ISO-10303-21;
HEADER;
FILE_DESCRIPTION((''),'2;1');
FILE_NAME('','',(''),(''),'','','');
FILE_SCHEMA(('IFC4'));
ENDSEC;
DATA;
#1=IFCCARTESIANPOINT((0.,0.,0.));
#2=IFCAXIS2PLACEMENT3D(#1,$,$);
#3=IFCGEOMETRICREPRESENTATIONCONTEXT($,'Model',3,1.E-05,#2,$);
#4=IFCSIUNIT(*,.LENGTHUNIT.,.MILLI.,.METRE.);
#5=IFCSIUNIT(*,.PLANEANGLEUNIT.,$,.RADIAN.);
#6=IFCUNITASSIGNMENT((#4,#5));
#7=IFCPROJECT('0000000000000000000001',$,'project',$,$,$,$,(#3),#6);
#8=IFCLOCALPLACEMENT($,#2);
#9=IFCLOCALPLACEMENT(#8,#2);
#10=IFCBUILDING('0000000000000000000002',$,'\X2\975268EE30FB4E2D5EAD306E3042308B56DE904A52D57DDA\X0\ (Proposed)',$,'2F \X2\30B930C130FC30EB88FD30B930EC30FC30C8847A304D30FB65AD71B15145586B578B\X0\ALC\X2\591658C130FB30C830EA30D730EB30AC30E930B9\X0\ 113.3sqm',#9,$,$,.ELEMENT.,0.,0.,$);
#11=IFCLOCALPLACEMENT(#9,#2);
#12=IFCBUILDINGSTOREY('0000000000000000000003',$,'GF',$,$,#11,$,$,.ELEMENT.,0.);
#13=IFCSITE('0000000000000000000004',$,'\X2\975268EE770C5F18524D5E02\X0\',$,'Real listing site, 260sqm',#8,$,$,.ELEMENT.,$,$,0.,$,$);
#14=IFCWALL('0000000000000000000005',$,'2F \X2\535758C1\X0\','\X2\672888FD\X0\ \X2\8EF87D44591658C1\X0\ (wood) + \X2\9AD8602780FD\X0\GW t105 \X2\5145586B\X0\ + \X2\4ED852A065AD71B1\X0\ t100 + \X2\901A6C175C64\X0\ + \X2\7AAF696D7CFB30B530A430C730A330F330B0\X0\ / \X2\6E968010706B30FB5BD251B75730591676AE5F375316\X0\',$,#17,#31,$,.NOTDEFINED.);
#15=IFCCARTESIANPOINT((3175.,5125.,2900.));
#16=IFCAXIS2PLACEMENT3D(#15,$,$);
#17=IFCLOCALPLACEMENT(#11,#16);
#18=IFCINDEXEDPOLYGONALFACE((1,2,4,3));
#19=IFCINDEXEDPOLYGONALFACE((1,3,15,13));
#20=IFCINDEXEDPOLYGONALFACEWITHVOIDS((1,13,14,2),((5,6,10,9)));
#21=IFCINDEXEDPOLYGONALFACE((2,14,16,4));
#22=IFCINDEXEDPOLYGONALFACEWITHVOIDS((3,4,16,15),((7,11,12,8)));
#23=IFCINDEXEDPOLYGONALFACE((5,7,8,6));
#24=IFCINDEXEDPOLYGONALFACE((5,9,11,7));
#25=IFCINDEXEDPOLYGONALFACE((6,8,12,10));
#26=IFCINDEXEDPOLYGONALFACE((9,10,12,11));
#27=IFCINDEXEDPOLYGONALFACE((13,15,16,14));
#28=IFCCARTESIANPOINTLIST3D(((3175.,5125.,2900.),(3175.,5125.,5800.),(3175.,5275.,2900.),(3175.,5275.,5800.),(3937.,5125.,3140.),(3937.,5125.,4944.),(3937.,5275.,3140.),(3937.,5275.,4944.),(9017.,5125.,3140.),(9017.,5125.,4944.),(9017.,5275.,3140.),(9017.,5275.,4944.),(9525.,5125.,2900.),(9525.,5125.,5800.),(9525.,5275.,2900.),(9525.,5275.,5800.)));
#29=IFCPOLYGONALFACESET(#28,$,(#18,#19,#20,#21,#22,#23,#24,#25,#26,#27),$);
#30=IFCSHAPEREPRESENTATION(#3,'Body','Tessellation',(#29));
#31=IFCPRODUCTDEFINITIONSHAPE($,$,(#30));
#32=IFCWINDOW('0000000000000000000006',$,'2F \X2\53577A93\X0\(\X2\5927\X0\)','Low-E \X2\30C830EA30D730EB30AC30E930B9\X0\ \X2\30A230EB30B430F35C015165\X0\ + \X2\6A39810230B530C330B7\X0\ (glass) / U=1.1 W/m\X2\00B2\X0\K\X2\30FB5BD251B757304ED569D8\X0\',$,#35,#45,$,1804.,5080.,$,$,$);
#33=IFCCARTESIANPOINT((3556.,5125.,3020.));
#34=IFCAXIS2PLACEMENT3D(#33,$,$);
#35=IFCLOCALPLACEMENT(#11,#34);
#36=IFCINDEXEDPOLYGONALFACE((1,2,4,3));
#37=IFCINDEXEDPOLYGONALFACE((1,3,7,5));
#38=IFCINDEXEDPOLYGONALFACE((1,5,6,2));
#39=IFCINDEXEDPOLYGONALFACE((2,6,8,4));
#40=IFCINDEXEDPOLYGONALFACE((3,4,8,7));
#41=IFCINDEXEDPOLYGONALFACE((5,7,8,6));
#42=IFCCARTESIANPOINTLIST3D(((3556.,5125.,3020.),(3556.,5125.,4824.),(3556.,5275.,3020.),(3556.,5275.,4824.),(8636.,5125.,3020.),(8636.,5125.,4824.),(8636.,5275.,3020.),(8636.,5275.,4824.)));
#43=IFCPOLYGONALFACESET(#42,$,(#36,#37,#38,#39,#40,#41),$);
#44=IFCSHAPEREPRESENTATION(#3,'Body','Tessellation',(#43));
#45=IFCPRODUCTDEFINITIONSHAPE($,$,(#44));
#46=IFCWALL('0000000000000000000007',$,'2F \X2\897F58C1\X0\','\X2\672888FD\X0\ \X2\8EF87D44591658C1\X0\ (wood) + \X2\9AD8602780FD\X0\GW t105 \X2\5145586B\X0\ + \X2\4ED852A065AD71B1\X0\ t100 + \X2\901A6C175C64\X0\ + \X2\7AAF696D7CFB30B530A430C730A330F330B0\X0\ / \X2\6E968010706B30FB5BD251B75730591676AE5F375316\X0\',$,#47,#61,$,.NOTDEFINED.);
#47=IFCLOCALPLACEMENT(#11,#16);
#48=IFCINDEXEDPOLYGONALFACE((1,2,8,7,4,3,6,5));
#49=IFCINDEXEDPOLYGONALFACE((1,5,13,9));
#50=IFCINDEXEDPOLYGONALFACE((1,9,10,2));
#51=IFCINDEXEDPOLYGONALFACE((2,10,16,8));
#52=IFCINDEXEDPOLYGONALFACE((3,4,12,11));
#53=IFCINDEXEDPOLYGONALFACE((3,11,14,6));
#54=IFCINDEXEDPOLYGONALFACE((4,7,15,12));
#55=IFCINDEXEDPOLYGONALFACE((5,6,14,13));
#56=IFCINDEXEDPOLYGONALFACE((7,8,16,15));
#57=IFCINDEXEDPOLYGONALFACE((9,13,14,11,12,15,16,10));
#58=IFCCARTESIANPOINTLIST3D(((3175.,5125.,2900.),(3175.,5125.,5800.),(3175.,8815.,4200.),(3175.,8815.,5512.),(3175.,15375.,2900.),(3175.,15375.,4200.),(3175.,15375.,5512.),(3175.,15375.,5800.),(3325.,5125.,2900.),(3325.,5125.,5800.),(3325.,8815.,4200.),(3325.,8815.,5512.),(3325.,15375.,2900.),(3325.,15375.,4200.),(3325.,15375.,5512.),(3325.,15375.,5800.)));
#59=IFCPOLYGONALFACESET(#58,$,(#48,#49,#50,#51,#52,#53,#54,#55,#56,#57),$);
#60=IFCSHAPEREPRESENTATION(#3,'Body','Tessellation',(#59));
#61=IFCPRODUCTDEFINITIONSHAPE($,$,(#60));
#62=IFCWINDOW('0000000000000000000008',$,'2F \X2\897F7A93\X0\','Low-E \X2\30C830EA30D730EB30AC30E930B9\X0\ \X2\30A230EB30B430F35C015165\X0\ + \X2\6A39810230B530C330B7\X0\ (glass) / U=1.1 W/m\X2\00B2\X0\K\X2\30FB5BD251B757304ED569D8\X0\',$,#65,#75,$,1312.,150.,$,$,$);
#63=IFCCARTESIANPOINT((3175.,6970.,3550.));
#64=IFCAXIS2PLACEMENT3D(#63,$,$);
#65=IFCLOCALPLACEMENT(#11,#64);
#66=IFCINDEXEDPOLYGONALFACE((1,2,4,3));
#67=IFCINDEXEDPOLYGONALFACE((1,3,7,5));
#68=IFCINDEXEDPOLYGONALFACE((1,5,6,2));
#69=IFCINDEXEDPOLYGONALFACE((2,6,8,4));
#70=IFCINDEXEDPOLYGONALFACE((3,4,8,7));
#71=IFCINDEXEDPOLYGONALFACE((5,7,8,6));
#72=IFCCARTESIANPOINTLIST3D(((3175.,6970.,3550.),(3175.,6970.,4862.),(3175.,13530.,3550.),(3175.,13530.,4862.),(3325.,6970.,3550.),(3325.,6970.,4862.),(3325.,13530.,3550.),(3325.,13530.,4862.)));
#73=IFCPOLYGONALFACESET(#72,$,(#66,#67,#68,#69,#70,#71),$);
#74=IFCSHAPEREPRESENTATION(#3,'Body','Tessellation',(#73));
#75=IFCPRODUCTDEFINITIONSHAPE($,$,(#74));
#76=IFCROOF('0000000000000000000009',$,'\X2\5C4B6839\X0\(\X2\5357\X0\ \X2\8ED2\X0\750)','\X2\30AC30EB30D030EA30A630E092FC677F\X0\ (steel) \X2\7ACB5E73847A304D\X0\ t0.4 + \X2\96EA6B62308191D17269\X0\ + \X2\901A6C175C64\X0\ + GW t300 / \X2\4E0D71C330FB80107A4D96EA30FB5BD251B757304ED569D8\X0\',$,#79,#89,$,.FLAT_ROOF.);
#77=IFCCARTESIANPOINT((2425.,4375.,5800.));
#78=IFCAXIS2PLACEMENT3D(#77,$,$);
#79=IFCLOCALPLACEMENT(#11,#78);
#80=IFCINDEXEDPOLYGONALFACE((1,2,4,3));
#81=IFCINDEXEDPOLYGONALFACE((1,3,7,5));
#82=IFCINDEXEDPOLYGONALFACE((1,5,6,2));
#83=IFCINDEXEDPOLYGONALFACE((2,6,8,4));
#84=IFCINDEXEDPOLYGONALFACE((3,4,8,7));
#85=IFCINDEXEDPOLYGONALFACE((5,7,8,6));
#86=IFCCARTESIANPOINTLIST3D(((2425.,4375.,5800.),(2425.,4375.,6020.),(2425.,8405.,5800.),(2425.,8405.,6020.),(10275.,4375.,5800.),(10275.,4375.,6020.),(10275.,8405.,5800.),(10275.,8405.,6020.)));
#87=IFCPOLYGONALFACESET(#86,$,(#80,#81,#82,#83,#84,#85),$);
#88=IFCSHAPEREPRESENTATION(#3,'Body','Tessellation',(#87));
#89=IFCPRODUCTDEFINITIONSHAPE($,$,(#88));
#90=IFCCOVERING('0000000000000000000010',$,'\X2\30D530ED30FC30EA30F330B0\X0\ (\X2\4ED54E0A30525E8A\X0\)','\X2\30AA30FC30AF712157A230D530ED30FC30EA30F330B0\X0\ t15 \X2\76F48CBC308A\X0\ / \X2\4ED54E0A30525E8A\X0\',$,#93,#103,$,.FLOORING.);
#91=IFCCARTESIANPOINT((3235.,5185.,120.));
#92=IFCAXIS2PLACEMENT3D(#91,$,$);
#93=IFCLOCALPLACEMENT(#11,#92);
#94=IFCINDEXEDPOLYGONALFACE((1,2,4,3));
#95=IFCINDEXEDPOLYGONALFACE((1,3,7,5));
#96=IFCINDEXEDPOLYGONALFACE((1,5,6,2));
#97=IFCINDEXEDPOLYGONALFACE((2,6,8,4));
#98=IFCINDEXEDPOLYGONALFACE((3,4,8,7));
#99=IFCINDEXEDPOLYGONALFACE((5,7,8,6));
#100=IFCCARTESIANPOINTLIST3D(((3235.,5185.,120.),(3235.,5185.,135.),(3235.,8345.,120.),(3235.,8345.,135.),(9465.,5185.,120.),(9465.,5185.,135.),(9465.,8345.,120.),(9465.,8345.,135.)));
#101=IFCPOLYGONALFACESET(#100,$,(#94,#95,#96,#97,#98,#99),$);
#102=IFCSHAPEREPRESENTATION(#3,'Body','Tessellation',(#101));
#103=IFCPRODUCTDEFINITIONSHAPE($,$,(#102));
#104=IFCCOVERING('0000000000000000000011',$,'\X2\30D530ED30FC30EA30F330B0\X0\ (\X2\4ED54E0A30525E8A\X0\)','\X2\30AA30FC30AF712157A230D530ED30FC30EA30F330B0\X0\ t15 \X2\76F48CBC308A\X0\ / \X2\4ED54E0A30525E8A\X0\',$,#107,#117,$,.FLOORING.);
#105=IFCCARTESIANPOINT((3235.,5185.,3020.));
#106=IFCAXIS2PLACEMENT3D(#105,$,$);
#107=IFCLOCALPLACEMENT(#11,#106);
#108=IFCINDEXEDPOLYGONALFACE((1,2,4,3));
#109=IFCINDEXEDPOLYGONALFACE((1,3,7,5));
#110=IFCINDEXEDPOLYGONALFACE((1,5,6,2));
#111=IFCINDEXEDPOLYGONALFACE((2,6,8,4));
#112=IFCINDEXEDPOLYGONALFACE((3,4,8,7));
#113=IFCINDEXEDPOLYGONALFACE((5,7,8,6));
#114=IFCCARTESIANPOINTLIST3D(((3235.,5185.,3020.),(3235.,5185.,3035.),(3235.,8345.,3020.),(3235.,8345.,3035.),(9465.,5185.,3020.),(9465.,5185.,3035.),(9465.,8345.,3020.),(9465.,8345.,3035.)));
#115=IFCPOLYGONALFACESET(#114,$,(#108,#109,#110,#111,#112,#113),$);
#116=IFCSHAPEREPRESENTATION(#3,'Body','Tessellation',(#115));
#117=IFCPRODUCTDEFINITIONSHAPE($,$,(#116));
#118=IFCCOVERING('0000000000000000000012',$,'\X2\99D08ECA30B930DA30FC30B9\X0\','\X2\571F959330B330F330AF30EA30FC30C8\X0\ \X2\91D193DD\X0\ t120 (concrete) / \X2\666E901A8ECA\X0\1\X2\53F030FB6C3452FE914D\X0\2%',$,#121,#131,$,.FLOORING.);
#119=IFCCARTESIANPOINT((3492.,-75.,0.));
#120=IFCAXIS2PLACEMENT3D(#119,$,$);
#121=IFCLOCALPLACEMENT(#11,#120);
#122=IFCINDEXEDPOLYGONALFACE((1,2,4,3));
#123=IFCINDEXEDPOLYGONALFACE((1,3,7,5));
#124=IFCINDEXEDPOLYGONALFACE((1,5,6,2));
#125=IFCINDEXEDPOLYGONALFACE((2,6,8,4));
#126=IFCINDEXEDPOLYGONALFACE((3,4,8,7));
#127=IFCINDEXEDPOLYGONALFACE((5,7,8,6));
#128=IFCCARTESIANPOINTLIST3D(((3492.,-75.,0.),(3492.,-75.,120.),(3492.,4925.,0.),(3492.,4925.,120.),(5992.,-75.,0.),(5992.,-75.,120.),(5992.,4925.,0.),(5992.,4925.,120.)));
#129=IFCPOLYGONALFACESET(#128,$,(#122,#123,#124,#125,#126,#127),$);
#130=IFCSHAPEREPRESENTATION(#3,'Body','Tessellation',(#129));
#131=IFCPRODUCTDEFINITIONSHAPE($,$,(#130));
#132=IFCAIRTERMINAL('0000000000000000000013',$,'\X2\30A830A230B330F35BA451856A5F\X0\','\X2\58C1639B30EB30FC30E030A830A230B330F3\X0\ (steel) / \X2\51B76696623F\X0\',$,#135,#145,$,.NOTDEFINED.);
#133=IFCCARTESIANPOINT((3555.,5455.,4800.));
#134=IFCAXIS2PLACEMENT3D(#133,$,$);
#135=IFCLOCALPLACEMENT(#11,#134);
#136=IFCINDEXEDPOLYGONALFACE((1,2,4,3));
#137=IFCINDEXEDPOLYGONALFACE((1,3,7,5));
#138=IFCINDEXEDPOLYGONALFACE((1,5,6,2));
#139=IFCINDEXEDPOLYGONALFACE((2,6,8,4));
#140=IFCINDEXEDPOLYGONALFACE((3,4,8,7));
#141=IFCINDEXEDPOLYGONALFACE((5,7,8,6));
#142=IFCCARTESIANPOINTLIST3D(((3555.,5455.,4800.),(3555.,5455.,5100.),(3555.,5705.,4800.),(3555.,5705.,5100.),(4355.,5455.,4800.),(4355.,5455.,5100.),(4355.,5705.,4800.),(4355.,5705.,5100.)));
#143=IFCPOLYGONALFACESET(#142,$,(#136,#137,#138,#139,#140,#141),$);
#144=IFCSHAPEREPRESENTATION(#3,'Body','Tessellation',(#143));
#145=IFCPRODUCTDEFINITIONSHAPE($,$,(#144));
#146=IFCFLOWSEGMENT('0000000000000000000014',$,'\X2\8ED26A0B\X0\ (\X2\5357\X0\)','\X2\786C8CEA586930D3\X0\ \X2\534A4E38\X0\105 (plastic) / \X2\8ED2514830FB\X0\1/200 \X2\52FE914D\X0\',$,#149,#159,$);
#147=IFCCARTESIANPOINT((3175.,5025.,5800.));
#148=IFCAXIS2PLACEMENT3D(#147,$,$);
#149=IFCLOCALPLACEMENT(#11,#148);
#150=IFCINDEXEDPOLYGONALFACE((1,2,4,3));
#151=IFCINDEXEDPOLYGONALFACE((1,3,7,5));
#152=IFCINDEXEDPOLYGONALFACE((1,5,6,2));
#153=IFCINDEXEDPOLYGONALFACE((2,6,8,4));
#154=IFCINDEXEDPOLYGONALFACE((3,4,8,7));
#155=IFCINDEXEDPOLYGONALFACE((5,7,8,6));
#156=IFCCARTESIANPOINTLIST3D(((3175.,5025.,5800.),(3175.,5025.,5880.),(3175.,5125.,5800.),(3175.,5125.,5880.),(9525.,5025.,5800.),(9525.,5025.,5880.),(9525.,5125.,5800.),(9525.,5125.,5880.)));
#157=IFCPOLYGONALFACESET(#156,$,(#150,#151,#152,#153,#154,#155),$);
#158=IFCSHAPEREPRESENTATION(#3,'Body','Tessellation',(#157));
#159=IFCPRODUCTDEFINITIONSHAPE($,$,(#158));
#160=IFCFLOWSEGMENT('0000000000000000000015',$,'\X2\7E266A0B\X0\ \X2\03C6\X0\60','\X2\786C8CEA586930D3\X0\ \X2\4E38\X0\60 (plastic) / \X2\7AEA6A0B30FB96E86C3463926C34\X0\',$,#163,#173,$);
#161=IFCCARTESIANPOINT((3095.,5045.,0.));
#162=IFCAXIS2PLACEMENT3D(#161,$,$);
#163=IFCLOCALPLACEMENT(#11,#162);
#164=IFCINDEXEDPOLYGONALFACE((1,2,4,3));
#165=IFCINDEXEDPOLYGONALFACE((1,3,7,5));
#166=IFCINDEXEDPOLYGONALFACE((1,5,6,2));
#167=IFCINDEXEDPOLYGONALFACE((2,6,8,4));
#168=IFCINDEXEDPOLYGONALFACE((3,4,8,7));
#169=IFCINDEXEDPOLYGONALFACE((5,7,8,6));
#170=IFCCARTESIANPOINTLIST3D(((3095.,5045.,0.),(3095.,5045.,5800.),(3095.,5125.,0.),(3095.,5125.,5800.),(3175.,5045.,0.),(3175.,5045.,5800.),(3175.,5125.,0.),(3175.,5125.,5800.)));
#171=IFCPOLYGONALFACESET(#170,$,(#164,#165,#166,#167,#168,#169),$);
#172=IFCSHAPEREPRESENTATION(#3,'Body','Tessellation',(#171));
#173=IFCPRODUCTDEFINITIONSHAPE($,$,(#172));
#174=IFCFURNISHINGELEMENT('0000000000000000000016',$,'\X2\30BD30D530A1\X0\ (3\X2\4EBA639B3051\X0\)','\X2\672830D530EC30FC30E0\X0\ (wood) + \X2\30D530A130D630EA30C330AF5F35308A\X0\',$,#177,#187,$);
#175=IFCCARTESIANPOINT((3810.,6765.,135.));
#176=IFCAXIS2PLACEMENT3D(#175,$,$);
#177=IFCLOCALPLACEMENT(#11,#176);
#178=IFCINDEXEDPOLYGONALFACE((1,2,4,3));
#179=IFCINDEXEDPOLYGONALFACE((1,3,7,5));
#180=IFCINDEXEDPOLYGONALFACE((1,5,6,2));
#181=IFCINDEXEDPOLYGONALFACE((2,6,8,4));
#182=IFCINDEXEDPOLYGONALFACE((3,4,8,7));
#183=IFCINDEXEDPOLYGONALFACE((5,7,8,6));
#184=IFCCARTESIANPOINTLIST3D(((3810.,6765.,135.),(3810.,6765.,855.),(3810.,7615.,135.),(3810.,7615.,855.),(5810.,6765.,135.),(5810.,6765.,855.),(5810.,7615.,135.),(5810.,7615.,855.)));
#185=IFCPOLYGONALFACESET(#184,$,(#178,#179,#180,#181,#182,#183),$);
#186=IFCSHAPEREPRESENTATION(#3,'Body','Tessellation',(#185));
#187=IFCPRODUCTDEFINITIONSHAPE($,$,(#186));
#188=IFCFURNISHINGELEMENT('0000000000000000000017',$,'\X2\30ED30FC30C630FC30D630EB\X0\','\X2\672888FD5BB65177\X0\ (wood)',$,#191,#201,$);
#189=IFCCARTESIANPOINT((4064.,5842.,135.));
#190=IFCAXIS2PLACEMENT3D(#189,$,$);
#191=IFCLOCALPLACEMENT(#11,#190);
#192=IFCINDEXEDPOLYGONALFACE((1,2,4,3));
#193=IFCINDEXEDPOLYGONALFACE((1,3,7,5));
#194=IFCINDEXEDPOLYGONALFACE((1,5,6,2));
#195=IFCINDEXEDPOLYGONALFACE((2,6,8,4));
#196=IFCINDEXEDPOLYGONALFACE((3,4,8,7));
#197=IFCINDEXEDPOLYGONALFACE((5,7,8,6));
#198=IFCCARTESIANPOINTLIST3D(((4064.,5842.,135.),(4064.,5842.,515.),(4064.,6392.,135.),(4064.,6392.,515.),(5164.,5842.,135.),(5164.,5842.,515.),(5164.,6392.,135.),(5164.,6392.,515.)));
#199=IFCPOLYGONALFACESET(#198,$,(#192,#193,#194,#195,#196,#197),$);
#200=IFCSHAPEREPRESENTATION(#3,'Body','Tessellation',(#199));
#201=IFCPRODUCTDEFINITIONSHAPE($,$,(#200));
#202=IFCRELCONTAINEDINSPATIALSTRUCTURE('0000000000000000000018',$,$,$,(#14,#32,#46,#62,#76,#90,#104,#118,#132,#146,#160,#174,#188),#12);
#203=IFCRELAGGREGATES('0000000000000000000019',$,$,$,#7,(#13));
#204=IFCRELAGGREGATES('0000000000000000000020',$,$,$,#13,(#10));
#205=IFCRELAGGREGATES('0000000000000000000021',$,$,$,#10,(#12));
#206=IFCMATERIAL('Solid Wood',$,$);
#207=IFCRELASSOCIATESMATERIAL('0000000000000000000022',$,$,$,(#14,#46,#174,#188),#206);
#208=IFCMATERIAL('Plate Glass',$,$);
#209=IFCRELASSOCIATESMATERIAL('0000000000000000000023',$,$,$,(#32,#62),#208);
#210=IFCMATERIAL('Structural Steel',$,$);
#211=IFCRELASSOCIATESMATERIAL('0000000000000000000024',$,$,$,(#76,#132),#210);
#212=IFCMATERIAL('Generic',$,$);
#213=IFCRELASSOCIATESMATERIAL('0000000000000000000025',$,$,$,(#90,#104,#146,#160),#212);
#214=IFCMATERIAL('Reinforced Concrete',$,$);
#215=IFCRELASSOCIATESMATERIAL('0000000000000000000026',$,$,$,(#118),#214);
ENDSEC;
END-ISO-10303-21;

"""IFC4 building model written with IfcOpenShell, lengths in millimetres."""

from ifc_helpers import new_model, si_unit, frame, frame_2d, origin, place, context, project, spatial, rectangle, extrude, material, element, fill, save


model = new_model("IFC4")

# Units and contexts
model_context = context("Model", 3, precision=1e-05, world=origin())
ifc_project = project(units=[si_unit("LENGTHUNIT", "METRE", prefix="MILLI"), si_unit("PLANEANGLEUNIT", "RADIAN")], contexts=[model_context])

# Site, building, storey
site_placement = place(None, origin())
site = spatial("IfcSite", under=ifc_project, at=site_placement, Name="青森県弘前市", ObjectType="Real listing site, 260sqm", CompositionType="ELEMENT", RefElevation=0.0)
building_placement = place(site_placement, origin())
building = spatial("IfcBuilding", under=site, at=building_placement, Name="青森・中庭のある回遊動線 (Proposed)", ObjectType="2F スチール製スレート葺き・断熱充填型ALC外壁・トリプルガラス 113.3sqm", CompositionType="ELEMENT", ElevationOfRefHeight=0.0, ElevationOfTerrain=0.0)
storey_placement = place(building_placement, origin())
storey = spatial("IfcBuildingStorey", under=building, at=storey_placement, Name="GF", CompositionType="ELEMENT", Elevation=0.0)

# Shared definitions
ifc_material_1 = material(Name="Solid Wood")

# Shared definitions
ifc_material_2 = material(Name="Reinforced Concrete")

# Shared definitions
ifc_material_3 = material(Name="Plate Glass")

# Walls, openings, windows
wall_1_placement = place(storey_placement, frame((3175.0, 5125.0, 2900.0)))
wall_1 = element("IfcWall", 1, at=wall_1_placement, inside=storey, material=ifc_material_1, Name="2F 南壁", Description="木製 軸組外壁 (wood) + 高性能GW t105 充填 + 付加断熱 t100 + 通気層 + 窯業系サイディング / 準耐火・寒冷地外皮強化", PredefinedType="NOTDEFINED", context=model_context, shape_type="SweptSolid", body=[
    extrude(rectangle(XDim=6350.0, YDim=150.0, at=frame_2d((3175.0, 75.0))), frame((3175.0, 5125.0, 2900.0)), (0.0, 0.0, 1.0), 2900.0),
])
opening_1_placement = place(storey_placement, frame((3556.0, 5125.0, 3020.0)))
opening_1 = element("IfcOpeningElement", 2, at=opening_1_placement, cuts=wall_1, PredefinedType="NOTDEFINED", context=model_context, shape_type="SweptSolid", body=[
    extrude(rectangle(XDim=5080.0, YDim=150.0, at=frame_2d((2540.0, 75.0))), frame((3556.0, 5125.0, 3020.0)), (0.0, 0.0, 1.0), 1804.0),
])
window_1_placement = place(storey_placement, frame((3556.0, 5125.0, 3020.0)))
window_1 = element("IfcWindow", 3, at=window_1_placement, inside=storey, material=ifc_material_3, Name="2F 南窓(大)", Description="Low-E トリプルガラス アルゴン封入 + 樹脂サッシ (glass) / U=1.1 W/m²K・寒冷地仕様", OverallHeight=1804.0, OverallWidth=5080.0, context=model_context, shape_type="SweptSolid", body=[
    extrude(rectangle(XDim=5080.0, YDim=150.0, at=frame_2d((2540.0, 75.0))), frame((3556.0, 5125.0, 3020.0)), (0.0, 0.0, 1.0), 1804.0),
])
fill(opening_1, window_1)
wall_2_placement = place(storey_placement, frame((3175.0, 5125.0, 2900.0)))
wall_2 = element("IfcWall", 4, at=wall_2_placement, inside=storey, material=ifc_material_1, Name="2F 西壁", Description="木製 軸組外壁 (wood) + 高性能GW t105 充填 + 付加断熱 t100 + 通気層 + 窯業系サイディング / 準耐火・寒冷地外皮強化", PredefinedType="NOTDEFINED", context=model_context, shape_type="SweptSolid", body=[
    extrude(rectangle(XDim=150.0, YDim=10250.0, at=frame_2d((75.0, 5125.0))), frame((3175.0, 5125.0, 2900.0)), (0.0, 0.0, 1.0), 2900.0),
])
opening_2_placement = place(storey_placement, frame((3175.0, 6970.0, 3550.0)))
opening_2 = element("IfcOpeningElement", 5, at=opening_2_placement, cuts=wall_2, PredefinedType="NOTDEFINED", context=model_context, shape_type="SweptSolid", body=[
    extrude(rectangle(XDim=150.0, YDim=6560.0, at=frame_2d((75.0, 3280.0))), frame((3175.0, 6970.0, 3550.0)), (0.0, 0.0, 1.0), 1312.0),
])
window_2_placement = place(storey_placement, frame((3175.0, 6970.0, 3550.0)))
window_2 = element("IfcWindow", 6, at=window_2_placement, inside=storey, material=ifc_material_3, Name="2F 西窓", Description="Low-E トリプルガラス アルゴン封入 + 樹脂サッシ (glass) / U=1.1 W/m²K・寒冷地仕様", OverallHeight=1312.0, OverallWidth=150.0, context=model_context, shape_type="SweptSolid", body=[
    extrude(rectangle(XDim=150.0, YDim=6560.0, at=frame_2d((75.0, 3280.0))), frame((3175.0, 6970.0, 3550.0)), (0.0, 0.0, 1.0), 1312.0),
])
fill(opening_2, window_2)

# Roof
ifc_material_4 = material(Name="Structural Steel")
for number, where, name in (
    (7, (2425.0, 4375.0, 5800.0), "屋根(南 軒750)"),
):
    element("IfcRoof", number, at=place(storey_placement, frame(where)), inside=storey, material=ifc_material_4, Name=name, Description="ガルバリウム鋼板 (steel) 立平葺き t0.4 + 雪止め金物 + 通気層 + GW t300 / 不燃・耐積雪・寒冷地仕様", PredefinedType="FLAT_ROOF", context=model_context, shape_type="SweptSolid", body=[
        extrude(rectangle(XDim=7850.0, YDim=4030.0, at=frame_2d((3925.0, 2015.0))), frame((2425.0, 4375.0, 5800.0)), (0.0, 0.0, 1.0), 220.0),
    ])

# Coverings
ifc_material_5 = material(Name="Generic")
covering_1_placement = place(storey_placement, frame((3235.0, 5185.0, 120.0)))
element("IfcCovering", 8, at=covering_1_placement, inside=storey, material=ifc_material_5, Name="フローリング (仕上げ床)", Description="オーク無垢フローリング t15 直貼り / 仕上げ床", PredefinedType="FLOORING", context=model_context, shape_type="SweptSolid", body=[
    extrude(rectangle(XDim=6230.0, YDim=3160.0, at=frame_2d((3115.0, 1580.0))), frame((3235.0, 5185.0, 120.0)), (0.0, 0.0, 1.0), 15.0),
])
covering_2_placement = place(storey_placement, frame((3235.0, 5185.0, 3020.0)))
element("IfcCovering", 9, at=covering_2_placement, inside=storey, material=ifc_material_5, Name="フローリング (仕上げ床)", Description="オーク無垢フローリング t15 直貼り / 仕上げ床", PredefinedType="FLOORING", context=model_context, shape_type="SweptSolid", body=[
    extrude(rectangle(XDim=6230.0, YDim=3160.0, at=frame_2d((3115.0, 1580.0))), frame((3235.0, 5185.0, 3020.0)), (0.0, 0.0, 1.0), 15.0),
])
covering_3_placement = place(storey_placement, frame((3492.0, -75.0, 0.0)))
element("IfcCovering", 10, at=covering_3_placement, inside=storey, material=ifc_material_2, Name="駐車スペース", Description="土間コンクリート 金鏝 t120 (concrete) / 普通車1台・水勾配2%", PredefinedType="FLOORING", context=model_context, shape_type="SweptSolid", body=[
    extrude(rectangle(XDim=2500.0, YDim=5000.0, at=frame_2d((1250.0, 2500.0))), frame((3492.0, -75.0, 0.0)), (0.0, 0.0, 1.0), 120.0),
])

# Air terminal
air_terminal_placement = place(storey_placement, frame((3555.0, 5455.0, 4800.0)))
element("IfcAirTerminal", 11, at=air_terminal_placement, inside=storey, material=ifc_material_4, Name="エアコン室内機", Description="壁掛ルームエアコン (steel) / 冷暖房", PredefinedType="NOTDEFINED", context=model_context, shape_type="SweptSolid", body=[
    extrude(rectangle(XDim=800.0, YDim=250.0, at=frame_2d((400.0, 125.0))), frame((3555.0, 5455.0, 4800.0)), (0.0, 0.0, 1.0), 300.0),
])

# Flow segments
flow_segment_1_placement = place(storey_placement, frame((3175.0, 5025.0, 5800.0)))
element("IfcFlowSegment", 12, at=flow_segment_1_placement, inside=storey, material=ifc_material_5, Name="軒樋 (南)", Description="硬質塩ビ 半丸105 (plastic) / 軒先・1/200 勾配", context=model_context, shape_type="SweptSolid", body=[
    extrude(rectangle(XDim=6350.0, YDim=100.0, at=frame_2d((3175.0, 50.0))), frame((3175.0, 5025.0, 5800.0)), (0.0, 0.0, 1.0), 80.0),
])
flow_segment_2_placement = place(storey_placement, frame((3095.0, 5045.0, 0.0)))
element("IfcFlowSegment", 13, at=flow_segment_2_placement, inside=storey, material=ifc_material_5, Name="縦樋 φ60", Description="硬質塩ビ 丸60 (plastic) / 竪樋・雨水排水", context=model_context, shape_type="SweptSolid", body=[
    extrude(rectangle(XDim=80.0, YDim=80.0, at=frame_2d((40.0, 40.0))), frame((3095.0, 5045.0, 0.0)), (0.0, 0.0, 1.0), 5800.0),
])

# Furnishing elements
furnishing_1_placement = place(storey_placement, frame((3810.0, 6765.0, 135.0)))
element("IfcFurnishingElement", 14, at=furnishing_1_placement, inside=storey, material=ifc_material_1, Name="ソファ (3人掛け)", Description="木フレーム (wood) + ファブリック張り", context=model_context, shape_type="SweptSolid", body=[
    extrude(rectangle(XDim=2000.0, YDim=850.0, at=frame_2d((1000.0, 425.0))), frame((3810.0, 6765.0, 135.0)), (0.0, 0.0, 1.0), 720.0),
])
furnishing_2_placement = place(storey_placement, frame((4064.0, 5842.0, 135.0)))
element("IfcFurnishingElement", 15, at=furnishing_2_placement, inside=storey, material=ifc_material_1, Name="ローテーブル", Description="木製家具 (wood)", context=model_context, shape_type="SweptSolid", body=[
    extrude(rectangle(XDim=1100.0, YDim=550.0, at=frame_2d((550.0, 275.0))), frame((4064.0, 5842.0, 135.0)), (0.0, 0.0, 1.0), 380.0),
])

save(model, "model.ifc")
